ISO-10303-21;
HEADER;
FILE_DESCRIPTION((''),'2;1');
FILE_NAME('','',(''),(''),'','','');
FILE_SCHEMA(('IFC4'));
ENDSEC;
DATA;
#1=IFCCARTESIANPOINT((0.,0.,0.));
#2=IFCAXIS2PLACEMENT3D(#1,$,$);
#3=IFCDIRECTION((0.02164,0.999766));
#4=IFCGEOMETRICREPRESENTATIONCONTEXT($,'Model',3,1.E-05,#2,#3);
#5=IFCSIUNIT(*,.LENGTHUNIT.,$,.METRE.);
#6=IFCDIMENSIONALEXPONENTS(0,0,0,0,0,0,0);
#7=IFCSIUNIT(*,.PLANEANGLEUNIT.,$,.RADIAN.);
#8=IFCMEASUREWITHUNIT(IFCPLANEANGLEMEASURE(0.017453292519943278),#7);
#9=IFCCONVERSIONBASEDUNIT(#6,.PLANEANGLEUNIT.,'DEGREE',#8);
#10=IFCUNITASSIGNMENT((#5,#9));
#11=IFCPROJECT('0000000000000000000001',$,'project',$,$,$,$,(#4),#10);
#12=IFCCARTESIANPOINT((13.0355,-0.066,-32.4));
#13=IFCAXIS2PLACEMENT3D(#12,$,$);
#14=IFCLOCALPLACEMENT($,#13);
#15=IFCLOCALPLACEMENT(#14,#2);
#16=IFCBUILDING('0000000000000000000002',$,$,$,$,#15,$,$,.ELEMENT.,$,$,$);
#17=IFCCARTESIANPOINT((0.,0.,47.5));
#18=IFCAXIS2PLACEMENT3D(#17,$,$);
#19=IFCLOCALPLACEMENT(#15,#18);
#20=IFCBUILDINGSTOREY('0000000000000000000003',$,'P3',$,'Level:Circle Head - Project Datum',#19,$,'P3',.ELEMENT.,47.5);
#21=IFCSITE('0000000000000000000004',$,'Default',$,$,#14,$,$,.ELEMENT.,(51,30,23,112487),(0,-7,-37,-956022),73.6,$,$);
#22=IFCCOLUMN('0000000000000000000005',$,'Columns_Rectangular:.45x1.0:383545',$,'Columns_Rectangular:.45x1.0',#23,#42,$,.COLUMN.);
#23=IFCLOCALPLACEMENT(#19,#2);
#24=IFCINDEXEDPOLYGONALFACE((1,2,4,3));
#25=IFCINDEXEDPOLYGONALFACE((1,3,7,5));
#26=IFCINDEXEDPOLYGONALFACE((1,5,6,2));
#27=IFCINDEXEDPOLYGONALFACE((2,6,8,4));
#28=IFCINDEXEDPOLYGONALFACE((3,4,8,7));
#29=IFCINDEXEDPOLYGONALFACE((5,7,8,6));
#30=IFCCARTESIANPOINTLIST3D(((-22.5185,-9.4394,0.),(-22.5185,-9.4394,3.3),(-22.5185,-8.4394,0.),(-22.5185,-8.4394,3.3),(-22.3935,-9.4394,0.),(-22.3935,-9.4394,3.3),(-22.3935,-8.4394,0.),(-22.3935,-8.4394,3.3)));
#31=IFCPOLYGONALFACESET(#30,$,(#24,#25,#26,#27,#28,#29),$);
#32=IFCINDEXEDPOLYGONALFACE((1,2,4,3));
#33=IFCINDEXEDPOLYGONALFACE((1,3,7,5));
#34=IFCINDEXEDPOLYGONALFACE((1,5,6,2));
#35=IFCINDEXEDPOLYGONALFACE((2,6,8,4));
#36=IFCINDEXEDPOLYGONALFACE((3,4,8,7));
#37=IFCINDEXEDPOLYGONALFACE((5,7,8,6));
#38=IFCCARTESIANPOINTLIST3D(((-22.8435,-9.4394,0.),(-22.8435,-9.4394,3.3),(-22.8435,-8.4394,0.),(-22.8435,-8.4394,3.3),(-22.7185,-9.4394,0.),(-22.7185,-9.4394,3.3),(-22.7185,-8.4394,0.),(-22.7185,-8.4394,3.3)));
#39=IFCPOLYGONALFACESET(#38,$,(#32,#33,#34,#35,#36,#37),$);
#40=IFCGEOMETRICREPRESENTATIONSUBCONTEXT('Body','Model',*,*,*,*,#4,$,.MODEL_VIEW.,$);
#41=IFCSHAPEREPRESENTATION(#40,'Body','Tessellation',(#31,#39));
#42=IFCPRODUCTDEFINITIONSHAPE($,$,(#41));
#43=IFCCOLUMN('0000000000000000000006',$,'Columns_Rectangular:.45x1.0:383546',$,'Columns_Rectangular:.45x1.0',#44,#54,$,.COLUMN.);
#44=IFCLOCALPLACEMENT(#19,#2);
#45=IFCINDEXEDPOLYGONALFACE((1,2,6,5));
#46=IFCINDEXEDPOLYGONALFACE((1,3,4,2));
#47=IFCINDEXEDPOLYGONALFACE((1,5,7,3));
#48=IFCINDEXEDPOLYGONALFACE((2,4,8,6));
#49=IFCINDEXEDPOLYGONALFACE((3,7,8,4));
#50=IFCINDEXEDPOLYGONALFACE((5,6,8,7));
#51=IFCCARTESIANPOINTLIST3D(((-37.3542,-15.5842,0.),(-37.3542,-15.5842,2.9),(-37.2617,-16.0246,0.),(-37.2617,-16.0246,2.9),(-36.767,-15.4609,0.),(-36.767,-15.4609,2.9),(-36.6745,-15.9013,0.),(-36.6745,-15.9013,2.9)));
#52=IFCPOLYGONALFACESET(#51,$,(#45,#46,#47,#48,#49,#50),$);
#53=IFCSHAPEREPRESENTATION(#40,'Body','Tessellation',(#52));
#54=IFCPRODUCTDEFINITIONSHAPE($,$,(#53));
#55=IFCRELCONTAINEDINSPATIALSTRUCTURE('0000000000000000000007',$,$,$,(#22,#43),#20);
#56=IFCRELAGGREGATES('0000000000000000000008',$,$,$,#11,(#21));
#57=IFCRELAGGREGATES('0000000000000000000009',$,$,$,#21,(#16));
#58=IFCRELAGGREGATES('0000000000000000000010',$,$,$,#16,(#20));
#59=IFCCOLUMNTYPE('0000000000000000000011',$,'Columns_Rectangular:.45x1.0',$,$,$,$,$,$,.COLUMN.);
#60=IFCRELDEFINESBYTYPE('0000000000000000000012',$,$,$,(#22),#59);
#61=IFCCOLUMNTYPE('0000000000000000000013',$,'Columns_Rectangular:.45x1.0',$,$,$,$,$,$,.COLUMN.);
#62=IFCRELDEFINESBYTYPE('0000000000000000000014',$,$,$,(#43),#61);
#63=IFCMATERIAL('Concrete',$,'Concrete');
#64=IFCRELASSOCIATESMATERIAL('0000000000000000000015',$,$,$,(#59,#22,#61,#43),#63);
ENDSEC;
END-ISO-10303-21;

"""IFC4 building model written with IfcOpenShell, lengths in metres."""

from ifc_helpers import new_model, entity, si_unit, converted_unit, direction, frame, origin, place, context, subcontext, project, spatial, indexed_curve, outline, extrude, source, transform, mapped, material, type_object, type_shapes, element, save


model = new_model("IFC4")

# Units and contexts
model_context = context("Model", 3, precision=1e-05, world=origin(), true_north=direction((0.02164, 0.999766)))
body_context = subcontext(model_context, "Body", "Model", "MODEL_VIEW")
ifc_project = project(units=[si_unit("LENGTHUNIT", "METRE"), converted_unit("PLANEANGLEUNIT", "DEGREE", entity("IfcPlaneAngleMeasure", 0.017453292519943278), si_unit("PLANEANGLEUNIT", "RADIAN"), dimensions=[0, 0, 0, 0, 0, 0, 0])], contexts=[model_context])

# Site, building, storey
site_placement = place(None, frame((13.0355, -0.066, -32.4)))
site = spatial("IfcSite", under=ifc_project, at=site_placement, Name="Default", CompositionType="ELEMENT", RefLatitude=(51, 30, 23, 112487), RefLongitude=(0, -7, -37, -956022), RefElevation=73.6)
building_placement = place(site_placement, origin())
building = spatial("IfcBuilding", under=site, at=building_placement, CompositionType="ELEMENT")
storey_placement = place(building_placement, frame((0.0, 0.0, 47.5)))
storey = spatial("IfcBuildingStorey", under=building, at=storey_placement, Name="P3", ObjectType="Level:Circle Head - Project Datum", LongName="P3", CompositionType="ELEMENT", Elevation=47.5)

# Columns
ifc_material = material(Name="Concrete", Category="Concrete")
column_type_1 = type_object("IfcColumnType", Name="Columns_Rectangular:.45x1.0", PredefinedType="COLUMN", material=ifc_material)
shared_shape_1 = source(origin(), body_context, "Body", "SweptSolid", [
    extrude(outline(indexed_curve([(-0.0625, -0.5), (0.0625, -0.5), (0.0625, 0.5), (-0.0625, 0.5), (-0.0625, -0.5)], self_intersect=False)), frame((-22.456, -8.9394, 47.5), z_axis=(0.0, 0.0, 1.0), x_axis=(-1.0, 0.0, 0.0)), (0.0, 0.0, 1.0), 3.3),
    extrude(outline(indexed_curve([(-0.0625, -0.5), (0.0625, -0.5), (0.0625, 0.5), (-0.0625, 0.5), (-0.0625, -0.5)], self_intersect=False)), frame((-22.781, -8.9394, 47.5)), (0.0, 0.0, 1.0), 3.3),
])
type_shapes(column_type_1, [shared_shape_1])
column_1_placement = place(storey_placement, frame((0.0, 0.0, -47.5)))
element("IfcColumn", 1, at=column_1_placement, inside=storey, type_object=column_type_1, material=ifc_material, Name="Columns_Rectangular:.45x1.0:383545", ObjectType="Columns_Rectangular:.45x1.0", PredefinedType="COLUMN", context=body_context, shape_type="MappedRepresentation", body=[
    mapped(shared_shape_1, transform((0.0, 0.0, 0.0), scale=1.0)),
])
column_type_2 = type_object("IfcColumnType", Name="Columns_Rectangular:.45x1.0", PredefinedType="COLUMN", material=ifc_material)
shared_shape_2 = source(origin(), body_context, "Body", "SweptSolid", [
    extrude(outline(indexed_curve([(-0.3, -0.225), (0.3, -0.225), (0.3, 0.225), (-0.3, 0.225), (-0.3, -0.225)], self_intersect=False)), frame((-37.0144, -15.7427, 47.5), z_axis=(0.0, 0.0, 1.0), x_axis=(0.978657, 0.2055, 0.0)), (0.0, 0.0, 1.0), 2.9),
])
type_shapes(column_type_2, [shared_shape_2])
column_2_placement = place(storey_placement, frame((0.0, 0.0, -47.5)))
element("IfcColumn", 2, at=column_2_placement, inside=storey, type_object=column_type_2, material=ifc_material, Name="Columns_Rectangular:.45x1.0:383546", ObjectType="Columns_Rectangular:.45x1.0", PredefinedType="COLUMN", context=body_context, shape_type="MappedRepresentation", body=[
    mapped(shared_shape_2, transform((0.0, 0.0, 0.0), scale=1.0)),
])

save(model, "model.ifc")
